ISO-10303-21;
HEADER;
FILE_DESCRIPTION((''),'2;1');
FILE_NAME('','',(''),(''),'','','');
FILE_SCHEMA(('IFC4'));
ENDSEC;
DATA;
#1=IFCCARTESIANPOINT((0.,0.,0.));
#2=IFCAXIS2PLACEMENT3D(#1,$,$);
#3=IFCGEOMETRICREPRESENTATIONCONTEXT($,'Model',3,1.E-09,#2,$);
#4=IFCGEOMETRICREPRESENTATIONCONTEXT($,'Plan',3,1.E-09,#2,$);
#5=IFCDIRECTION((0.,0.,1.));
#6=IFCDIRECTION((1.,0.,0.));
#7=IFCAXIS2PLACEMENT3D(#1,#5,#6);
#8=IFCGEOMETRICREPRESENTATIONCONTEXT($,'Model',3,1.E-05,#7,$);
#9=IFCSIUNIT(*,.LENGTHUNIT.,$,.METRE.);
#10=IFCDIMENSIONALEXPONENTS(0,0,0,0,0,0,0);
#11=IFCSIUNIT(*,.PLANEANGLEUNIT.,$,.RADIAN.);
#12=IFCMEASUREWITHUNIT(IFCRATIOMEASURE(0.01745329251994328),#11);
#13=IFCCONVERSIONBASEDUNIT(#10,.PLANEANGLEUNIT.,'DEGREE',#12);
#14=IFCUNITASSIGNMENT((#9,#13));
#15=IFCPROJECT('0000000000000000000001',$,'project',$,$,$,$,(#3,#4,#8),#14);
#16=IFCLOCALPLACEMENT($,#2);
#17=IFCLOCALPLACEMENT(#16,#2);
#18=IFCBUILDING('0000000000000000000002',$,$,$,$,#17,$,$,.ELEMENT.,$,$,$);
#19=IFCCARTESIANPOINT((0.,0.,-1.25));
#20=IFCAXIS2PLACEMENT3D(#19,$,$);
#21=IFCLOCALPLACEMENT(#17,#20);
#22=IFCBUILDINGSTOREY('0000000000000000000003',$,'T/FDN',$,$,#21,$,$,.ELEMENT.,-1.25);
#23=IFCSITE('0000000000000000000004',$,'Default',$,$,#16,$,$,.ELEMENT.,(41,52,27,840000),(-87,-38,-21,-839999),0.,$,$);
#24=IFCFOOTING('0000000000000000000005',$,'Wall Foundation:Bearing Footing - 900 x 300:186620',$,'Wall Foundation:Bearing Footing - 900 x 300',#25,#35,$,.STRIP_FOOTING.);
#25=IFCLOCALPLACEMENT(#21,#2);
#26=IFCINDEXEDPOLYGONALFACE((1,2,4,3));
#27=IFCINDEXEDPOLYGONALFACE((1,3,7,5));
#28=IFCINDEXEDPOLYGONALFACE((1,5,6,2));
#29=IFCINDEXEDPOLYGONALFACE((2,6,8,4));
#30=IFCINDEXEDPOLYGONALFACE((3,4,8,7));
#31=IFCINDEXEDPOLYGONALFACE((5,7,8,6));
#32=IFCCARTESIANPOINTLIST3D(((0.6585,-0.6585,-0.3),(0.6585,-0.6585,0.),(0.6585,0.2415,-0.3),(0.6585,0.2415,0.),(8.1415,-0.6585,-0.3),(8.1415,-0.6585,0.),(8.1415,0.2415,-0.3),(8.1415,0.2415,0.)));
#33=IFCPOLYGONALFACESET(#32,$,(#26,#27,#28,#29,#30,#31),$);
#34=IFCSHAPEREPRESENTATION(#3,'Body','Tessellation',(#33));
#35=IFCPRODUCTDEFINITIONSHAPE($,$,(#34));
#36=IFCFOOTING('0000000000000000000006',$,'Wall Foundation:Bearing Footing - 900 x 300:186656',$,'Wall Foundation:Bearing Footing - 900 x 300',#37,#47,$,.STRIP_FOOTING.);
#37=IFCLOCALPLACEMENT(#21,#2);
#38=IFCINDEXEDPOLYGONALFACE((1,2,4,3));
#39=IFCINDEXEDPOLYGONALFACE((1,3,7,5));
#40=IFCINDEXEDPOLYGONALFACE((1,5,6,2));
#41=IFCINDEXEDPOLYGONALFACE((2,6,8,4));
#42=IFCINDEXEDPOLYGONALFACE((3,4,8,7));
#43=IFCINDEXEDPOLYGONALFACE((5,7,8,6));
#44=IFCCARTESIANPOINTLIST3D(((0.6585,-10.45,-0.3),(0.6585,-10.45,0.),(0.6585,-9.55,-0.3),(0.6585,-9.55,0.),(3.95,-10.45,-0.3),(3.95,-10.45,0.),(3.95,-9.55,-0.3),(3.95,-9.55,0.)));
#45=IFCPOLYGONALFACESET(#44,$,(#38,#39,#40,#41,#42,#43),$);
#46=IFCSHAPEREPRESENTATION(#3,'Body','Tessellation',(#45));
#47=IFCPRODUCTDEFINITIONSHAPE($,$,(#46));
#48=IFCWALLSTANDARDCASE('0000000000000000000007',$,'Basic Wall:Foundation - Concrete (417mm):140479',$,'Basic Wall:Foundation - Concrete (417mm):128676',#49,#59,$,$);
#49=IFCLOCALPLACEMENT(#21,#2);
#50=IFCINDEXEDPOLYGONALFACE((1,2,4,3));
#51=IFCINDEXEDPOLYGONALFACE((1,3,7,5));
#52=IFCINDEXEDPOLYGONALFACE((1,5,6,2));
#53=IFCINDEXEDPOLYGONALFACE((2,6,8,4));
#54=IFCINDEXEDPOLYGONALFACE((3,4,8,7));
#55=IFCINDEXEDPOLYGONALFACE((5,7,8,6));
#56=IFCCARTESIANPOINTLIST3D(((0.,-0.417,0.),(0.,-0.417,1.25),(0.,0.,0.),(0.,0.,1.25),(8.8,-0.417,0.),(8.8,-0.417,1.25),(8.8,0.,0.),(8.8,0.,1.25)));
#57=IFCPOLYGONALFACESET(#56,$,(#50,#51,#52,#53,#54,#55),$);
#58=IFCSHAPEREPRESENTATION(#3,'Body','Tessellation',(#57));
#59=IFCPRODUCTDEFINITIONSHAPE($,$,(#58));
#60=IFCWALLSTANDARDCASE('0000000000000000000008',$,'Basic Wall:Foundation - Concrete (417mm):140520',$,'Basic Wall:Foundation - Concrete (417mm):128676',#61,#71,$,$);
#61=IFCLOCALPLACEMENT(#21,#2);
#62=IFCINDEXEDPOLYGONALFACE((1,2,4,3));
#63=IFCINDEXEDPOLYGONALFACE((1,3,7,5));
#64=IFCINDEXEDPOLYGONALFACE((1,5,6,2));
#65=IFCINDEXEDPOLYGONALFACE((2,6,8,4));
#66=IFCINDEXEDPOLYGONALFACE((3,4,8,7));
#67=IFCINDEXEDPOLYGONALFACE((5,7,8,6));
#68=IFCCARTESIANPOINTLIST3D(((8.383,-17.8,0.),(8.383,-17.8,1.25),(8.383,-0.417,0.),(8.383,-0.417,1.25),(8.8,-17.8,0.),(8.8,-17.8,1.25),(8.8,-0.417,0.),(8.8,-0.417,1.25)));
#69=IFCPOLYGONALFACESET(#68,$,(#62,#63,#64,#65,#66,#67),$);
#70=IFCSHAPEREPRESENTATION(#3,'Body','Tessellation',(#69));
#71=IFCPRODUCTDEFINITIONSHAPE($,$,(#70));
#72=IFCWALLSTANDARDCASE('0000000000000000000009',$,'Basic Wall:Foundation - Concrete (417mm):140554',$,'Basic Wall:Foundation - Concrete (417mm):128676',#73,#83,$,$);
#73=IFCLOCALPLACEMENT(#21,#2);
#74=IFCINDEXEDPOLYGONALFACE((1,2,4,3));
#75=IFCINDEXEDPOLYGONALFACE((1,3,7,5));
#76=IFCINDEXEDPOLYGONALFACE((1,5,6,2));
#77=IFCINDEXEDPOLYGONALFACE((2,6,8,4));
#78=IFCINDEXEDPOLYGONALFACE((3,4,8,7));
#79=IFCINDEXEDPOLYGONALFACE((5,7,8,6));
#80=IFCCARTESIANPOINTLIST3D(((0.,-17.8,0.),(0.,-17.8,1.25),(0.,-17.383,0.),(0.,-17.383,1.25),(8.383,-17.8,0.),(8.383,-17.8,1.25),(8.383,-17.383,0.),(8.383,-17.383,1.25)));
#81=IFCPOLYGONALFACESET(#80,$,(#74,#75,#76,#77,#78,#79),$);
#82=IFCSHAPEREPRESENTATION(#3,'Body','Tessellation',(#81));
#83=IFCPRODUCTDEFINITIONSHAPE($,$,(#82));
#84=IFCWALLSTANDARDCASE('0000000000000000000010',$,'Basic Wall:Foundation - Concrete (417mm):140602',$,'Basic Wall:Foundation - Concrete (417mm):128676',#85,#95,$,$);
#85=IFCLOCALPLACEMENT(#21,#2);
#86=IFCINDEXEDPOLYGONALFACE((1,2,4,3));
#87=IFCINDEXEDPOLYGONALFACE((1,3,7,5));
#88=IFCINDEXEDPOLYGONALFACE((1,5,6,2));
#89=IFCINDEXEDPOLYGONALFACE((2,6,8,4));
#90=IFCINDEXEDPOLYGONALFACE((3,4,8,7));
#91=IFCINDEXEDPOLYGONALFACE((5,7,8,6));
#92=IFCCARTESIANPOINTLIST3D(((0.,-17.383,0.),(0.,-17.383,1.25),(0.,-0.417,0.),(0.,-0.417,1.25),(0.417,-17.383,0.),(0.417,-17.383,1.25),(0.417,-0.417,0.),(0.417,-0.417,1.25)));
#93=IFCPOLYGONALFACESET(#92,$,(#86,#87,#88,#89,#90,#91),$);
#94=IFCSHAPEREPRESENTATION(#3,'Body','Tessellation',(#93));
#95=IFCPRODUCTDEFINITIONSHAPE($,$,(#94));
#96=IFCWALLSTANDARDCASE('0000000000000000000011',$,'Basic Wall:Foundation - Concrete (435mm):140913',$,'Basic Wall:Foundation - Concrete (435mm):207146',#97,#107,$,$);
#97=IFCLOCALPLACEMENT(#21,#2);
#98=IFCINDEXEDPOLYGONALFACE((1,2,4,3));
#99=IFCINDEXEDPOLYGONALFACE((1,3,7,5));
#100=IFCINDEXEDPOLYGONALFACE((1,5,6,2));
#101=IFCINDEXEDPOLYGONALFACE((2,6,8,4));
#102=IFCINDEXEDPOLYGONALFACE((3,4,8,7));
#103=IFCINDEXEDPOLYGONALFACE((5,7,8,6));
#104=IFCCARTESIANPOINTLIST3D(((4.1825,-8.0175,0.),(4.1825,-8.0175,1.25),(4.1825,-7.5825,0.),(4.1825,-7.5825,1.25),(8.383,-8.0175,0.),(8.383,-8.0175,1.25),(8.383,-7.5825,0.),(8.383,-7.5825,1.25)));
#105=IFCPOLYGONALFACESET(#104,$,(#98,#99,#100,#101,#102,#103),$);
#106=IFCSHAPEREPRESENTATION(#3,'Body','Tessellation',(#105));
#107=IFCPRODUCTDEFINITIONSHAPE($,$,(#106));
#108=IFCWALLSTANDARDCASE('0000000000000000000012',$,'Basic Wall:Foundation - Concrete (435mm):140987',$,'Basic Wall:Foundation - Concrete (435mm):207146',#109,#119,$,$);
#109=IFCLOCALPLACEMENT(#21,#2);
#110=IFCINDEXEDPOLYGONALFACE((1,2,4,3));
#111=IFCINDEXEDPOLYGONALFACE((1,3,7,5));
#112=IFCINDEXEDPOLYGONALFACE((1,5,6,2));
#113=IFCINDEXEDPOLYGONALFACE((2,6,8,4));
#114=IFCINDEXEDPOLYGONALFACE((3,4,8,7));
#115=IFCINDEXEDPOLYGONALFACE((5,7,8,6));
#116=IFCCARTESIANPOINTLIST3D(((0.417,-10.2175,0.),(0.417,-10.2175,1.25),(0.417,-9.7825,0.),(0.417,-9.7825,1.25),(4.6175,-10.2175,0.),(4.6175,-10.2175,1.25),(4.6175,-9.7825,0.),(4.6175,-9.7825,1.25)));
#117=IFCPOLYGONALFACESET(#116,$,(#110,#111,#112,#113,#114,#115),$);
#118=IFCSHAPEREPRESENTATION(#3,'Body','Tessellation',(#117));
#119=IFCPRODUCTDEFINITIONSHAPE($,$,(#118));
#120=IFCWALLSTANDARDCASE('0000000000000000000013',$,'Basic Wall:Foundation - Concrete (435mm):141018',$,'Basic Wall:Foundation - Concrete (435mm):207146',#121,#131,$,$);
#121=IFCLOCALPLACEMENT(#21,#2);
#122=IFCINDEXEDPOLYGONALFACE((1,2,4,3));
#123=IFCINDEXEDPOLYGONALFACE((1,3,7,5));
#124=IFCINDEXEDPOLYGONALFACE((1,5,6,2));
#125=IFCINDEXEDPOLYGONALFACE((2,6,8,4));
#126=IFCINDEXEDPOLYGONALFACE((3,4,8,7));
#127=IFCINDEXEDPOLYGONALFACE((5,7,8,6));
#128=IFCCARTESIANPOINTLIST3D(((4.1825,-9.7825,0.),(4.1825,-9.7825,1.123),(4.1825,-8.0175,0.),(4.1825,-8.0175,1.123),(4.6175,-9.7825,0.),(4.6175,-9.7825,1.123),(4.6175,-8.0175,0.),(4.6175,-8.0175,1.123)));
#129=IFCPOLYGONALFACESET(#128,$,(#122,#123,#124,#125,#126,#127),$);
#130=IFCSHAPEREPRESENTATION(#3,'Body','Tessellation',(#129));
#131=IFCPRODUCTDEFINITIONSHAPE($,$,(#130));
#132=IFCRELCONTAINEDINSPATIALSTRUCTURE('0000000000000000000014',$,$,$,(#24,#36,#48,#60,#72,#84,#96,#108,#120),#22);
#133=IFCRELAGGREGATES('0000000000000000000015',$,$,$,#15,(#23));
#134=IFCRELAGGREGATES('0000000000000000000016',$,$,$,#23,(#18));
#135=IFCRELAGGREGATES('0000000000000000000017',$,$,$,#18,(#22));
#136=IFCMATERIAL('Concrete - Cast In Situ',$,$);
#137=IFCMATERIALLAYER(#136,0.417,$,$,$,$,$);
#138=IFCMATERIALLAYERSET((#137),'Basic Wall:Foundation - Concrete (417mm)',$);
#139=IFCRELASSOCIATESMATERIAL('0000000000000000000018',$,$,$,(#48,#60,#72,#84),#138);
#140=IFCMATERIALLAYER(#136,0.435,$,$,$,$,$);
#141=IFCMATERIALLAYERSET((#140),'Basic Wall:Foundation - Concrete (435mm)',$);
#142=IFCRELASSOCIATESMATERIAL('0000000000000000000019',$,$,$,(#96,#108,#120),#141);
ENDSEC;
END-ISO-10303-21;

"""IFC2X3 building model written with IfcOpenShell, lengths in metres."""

from ifc_helpers import new_model, entity, si_unit, converted_unit, frame, frame_2d, origin, origin_with_axes, origin_2d_with_axis, place, context, project, spatial, rectangle, extrude, material, layer, layer_set, layer_usage, element, save


model = new_model("IFC2X3")

# Units and contexts
model_context_1 = context("Model", 3, precision=1e-09, world=origin())
plan_context = context("Plan", 3, precision=1e-09, world=origin())
model_context_2 = context("Model", 3, precision=1e-05, world=origin_with_axes())
ifc_project = project(units=[si_unit("LENGTHUNIT", "METRE"), converted_unit("PLANEANGLEUNIT", "DEGREE", entity("IfcRatioMeasure", 0.01745329251994328), si_unit("PLANEANGLEUNIT", "RADIAN"), dimensions=[0, 0, 0, 0, 0, 0, 0])], contexts=[model_context_1, plan_context, model_context_2])

# Site, building, storey
site_placement = place(None, origin())
site = spatial("IfcSite", under=ifc_project, at=site_placement, Name="Default", CompositionType="ELEMENT", RefLatitude=(41, 52, 27, 840000), RefLongitude=(-87, -38, -21, -839999), RefElevation=0.0)
building_placement = place(site_placement, origin())
building = spatial("IfcBuilding", under=site, at=building_placement, CompositionType="ELEMENT")
storey_placement = place(building_placement, frame((0.0, 0.0, -1.25)))
storey = spatial("IfcBuildingStorey", under=building, at=storey_placement, Name="T/FDN", CompositionType="ELEMENT", Elevation=-1.25)

# Footings
footing_1_placement = place(storey_placement, origin())
element("IfcFooting", 1, at=footing_1_placement, inside=storey, Name="Wall Foundation:Bearing Footing - 900 x 300:186620", ObjectType="Wall Foundation:Bearing Footing - 900 x 300", PredefinedType="STRIP_FOOTING", context=model_context_1, shape_type="SweptSolid", body=[
    extrude(rectangle(XDim=7.483, YDim=0.9, at=origin_2d_with_axis()), frame((4.4, -0.2085, -0.3), z_axis=(0.0, 0.0, 1.0), x_axis=(-1.0, 0.0, 0.0)), (0.0, 0.0, 1.0), 0.3),
])
footing_2_placement = place(storey_placement, origin())
element("IfcFooting", 2, at=footing_2_placement, inside=storey, Name="Wall Foundation:Bearing Footing - 900 x 300:186656", ObjectType="Wall Foundation:Bearing Footing - 900 x 300", PredefinedType="STRIP_FOOTING", context=model_context_1, shape_type="SweptSolid", body=[
    extrude(rectangle(XDim=3.2915, YDim=0.9, at=origin_2d_with_axis()), frame((2.3042, -10.0, -0.3)), (0.0, 0.0, 1.0), 0.3),
])

# Walls
ifc_material = material(Name="Concrete - Cast In Situ")
ifc_layer_1 = layer(ifc_material, 0.417)
ifc_layer_set_1 = layer_set([ifc_layer_1], Name="Basic Wall:Foundation - Concrete (417mm)")
ifc_layer_usage_1 = layer_usage(ifc_layer_set_1, "AXIS2", "NEGATIVE", 0.2085)
wall_1_placement = place(storey_placement, frame((0.0, -0.2085, 0.0)))
element("IfcWallStandardCase", 3, at=wall_1_placement, inside=storey, material=ifc_layer_usage_1, Name="Basic Wall:Foundation - Concrete (417mm):140479", ObjectType="Basic Wall:Foundation - Concrete (417mm):128676", context=model_context_1, shape_type="SweptSolid", body=[
    extrude(rectangle(XDim=8.8, YDim=0.417, at=frame_2d((4.4, 0.0), x_axis=(-1.0, 0.0))), origin(), (0.0, 0.0, 1.0), 1.25),
])
ifc_layer_usage_2 = layer_usage(ifc_layer_set_1, "AXIS2", "NEGATIVE", 0.2085)
wall_2_placement = place(storey_placement, frame((8.5915, -0.417, 0.0), z_axis=(0.0, 0.0, 1.0), x_axis=(0.0, -1.0, 0.0)))
element("IfcWallStandardCase", 4, at=wall_2_placement, inside=storey, material=ifc_layer_usage_2, Name="Basic Wall:Foundation - Concrete (417mm):140520", ObjectType="Basic Wall:Foundation - Concrete (417mm):128676", context=model_context_1, shape_type="SweptSolid", body=[
    extrude(rectangle(XDim=17.383, YDim=0.417, at=frame_2d((8.6915, 0.0), x_axis=(-1.0, 0.0))), origin(), (0.0, 0.0, 1.0), 1.25),
])
ifc_layer_usage_3 = layer_usage(ifc_layer_set_1, "AXIS2", "NEGATIVE", 0.2085)
wall_3_placement = place(storey_placement, frame((8.383, -17.5915, 0.0), z_axis=(0.0, 0.0, 1.0), x_axis=(-1.0, 0.0, 0.0)))
element("IfcWallStandardCase", 5, at=wall_3_placement, inside=storey, material=ifc_layer_usage_3, Name="Basic Wall:Foundation - Concrete (417mm):140554", ObjectType="Basic Wall:Foundation - Concrete (417mm):128676", context=model_context_1, shape_type="SweptSolid", body=[
    extrude(rectangle(XDim=8.383, YDim=0.417, at=frame_2d((4.1915, 0.0), x_axis=(-1.0, 0.0))), origin(), (0.0, 0.0, 1.0), 1.25),
])
ifc_layer_usage_4 = layer_usage(ifc_layer_set_1, "AXIS2", "NEGATIVE", 0.2085)
wall_4_placement = place(storey_placement, frame((0.2085, -17.383, 0.0), z_axis=(0.0, 0.0, 1.0), x_axis=(0.0, 1.0, 0.0)))
element("IfcWallStandardCase", 6, at=wall_4_placement, inside=storey, material=ifc_layer_usage_4, Name="Basic Wall:Foundation - Concrete (417mm):140602", ObjectType="Basic Wall:Foundation - Concrete (417mm):128676", context=model_context_1, shape_type="SweptSolid", body=[
    extrude(rectangle(XDim=16.966, YDim=0.417, at=frame_2d((8.483, 0.0), x_axis=(-1.0, 0.0))), origin(), (0.0, 0.0, 1.0), 1.25),
])
ifc_layer_2 = layer(ifc_material, 0.435)
ifc_layer_set_2 = layer_set([ifc_layer_2], Name="Basic Wall:Foundation - Concrete (435mm)")
ifc_layer_usage_5 = layer_usage(ifc_layer_set_2, "AXIS2", "NEGATIVE", 0.2175)
wall_5_placement = place(storey_placement, frame((8.383, -7.8, 0.0), z_axis=(0.0, 0.0, 1.0), x_axis=(-1.0, 0.0, 0.0)))
element("IfcWallStandardCase", 7, at=wall_5_placement, inside=storey, material=ifc_layer_usage_5, Name="Basic Wall:Foundation - Concrete (435mm):140913", ObjectType="Basic Wall:Foundation - Concrete (435mm):207146", context=model_context_1, shape_type="SweptSolid", body=[
    extrude(rectangle(XDim=4.2005, YDim=0.435, at=frame_2d((2.1002, 0.0), x_axis=(-1.0, 0.0))), origin(), (0.0, 0.0, 1.0), 1.25),
])
ifc_layer_usage_6 = layer_usage(ifc_layer_set_2, "AXIS2", "NEGATIVE", 0.2175)
wall_6_placement = place(storey_placement, frame((0.417, -10.0, 0.0)))
element("IfcWallStandardCase", 8, at=wall_6_placement, inside=storey, material=ifc_layer_usage_6, Name="Basic Wall:Foundation - Concrete (435mm):140987", ObjectType="Basic Wall:Foundation - Concrete (435mm):207146", context=model_context_1, shape_type="SweptSolid", body=[
    extrude(rectangle(XDim=4.2005, YDim=0.435, at=frame_2d((2.1002, 0.0), x_axis=(-1.0, 0.0))), origin(), (0.0, 0.0, 1.0), 1.25),
])
ifc_layer_usage_7 = layer_usage(ifc_layer_set_2, "AXIS2", "NEGATIVE", 0.2175)
wall_7_placement = place(storey_placement, frame((4.4, -9.7825, 0.0), z_axis=(0.0, 0.0, 1.0), x_axis=(0.0, 1.0, 0.0)))
element("IfcWallStandardCase", 9, at=wall_7_placement, inside=storey, material=ifc_layer_usage_7, Name="Basic Wall:Foundation - Concrete (435mm):141018", ObjectType="Basic Wall:Foundation - Concrete (435mm):207146", context=model_context_1, shape_type="SweptSolid", body=[
    extrude(rectangle(XDim=1.765, YDim=0.435, at=frame_2d((0.8825, 0.0), x_axis=(-1.0, 0.0))), origin(), (0.0, 0.0, 1.0), 1.123),
])

save(model, "model.ifc")
